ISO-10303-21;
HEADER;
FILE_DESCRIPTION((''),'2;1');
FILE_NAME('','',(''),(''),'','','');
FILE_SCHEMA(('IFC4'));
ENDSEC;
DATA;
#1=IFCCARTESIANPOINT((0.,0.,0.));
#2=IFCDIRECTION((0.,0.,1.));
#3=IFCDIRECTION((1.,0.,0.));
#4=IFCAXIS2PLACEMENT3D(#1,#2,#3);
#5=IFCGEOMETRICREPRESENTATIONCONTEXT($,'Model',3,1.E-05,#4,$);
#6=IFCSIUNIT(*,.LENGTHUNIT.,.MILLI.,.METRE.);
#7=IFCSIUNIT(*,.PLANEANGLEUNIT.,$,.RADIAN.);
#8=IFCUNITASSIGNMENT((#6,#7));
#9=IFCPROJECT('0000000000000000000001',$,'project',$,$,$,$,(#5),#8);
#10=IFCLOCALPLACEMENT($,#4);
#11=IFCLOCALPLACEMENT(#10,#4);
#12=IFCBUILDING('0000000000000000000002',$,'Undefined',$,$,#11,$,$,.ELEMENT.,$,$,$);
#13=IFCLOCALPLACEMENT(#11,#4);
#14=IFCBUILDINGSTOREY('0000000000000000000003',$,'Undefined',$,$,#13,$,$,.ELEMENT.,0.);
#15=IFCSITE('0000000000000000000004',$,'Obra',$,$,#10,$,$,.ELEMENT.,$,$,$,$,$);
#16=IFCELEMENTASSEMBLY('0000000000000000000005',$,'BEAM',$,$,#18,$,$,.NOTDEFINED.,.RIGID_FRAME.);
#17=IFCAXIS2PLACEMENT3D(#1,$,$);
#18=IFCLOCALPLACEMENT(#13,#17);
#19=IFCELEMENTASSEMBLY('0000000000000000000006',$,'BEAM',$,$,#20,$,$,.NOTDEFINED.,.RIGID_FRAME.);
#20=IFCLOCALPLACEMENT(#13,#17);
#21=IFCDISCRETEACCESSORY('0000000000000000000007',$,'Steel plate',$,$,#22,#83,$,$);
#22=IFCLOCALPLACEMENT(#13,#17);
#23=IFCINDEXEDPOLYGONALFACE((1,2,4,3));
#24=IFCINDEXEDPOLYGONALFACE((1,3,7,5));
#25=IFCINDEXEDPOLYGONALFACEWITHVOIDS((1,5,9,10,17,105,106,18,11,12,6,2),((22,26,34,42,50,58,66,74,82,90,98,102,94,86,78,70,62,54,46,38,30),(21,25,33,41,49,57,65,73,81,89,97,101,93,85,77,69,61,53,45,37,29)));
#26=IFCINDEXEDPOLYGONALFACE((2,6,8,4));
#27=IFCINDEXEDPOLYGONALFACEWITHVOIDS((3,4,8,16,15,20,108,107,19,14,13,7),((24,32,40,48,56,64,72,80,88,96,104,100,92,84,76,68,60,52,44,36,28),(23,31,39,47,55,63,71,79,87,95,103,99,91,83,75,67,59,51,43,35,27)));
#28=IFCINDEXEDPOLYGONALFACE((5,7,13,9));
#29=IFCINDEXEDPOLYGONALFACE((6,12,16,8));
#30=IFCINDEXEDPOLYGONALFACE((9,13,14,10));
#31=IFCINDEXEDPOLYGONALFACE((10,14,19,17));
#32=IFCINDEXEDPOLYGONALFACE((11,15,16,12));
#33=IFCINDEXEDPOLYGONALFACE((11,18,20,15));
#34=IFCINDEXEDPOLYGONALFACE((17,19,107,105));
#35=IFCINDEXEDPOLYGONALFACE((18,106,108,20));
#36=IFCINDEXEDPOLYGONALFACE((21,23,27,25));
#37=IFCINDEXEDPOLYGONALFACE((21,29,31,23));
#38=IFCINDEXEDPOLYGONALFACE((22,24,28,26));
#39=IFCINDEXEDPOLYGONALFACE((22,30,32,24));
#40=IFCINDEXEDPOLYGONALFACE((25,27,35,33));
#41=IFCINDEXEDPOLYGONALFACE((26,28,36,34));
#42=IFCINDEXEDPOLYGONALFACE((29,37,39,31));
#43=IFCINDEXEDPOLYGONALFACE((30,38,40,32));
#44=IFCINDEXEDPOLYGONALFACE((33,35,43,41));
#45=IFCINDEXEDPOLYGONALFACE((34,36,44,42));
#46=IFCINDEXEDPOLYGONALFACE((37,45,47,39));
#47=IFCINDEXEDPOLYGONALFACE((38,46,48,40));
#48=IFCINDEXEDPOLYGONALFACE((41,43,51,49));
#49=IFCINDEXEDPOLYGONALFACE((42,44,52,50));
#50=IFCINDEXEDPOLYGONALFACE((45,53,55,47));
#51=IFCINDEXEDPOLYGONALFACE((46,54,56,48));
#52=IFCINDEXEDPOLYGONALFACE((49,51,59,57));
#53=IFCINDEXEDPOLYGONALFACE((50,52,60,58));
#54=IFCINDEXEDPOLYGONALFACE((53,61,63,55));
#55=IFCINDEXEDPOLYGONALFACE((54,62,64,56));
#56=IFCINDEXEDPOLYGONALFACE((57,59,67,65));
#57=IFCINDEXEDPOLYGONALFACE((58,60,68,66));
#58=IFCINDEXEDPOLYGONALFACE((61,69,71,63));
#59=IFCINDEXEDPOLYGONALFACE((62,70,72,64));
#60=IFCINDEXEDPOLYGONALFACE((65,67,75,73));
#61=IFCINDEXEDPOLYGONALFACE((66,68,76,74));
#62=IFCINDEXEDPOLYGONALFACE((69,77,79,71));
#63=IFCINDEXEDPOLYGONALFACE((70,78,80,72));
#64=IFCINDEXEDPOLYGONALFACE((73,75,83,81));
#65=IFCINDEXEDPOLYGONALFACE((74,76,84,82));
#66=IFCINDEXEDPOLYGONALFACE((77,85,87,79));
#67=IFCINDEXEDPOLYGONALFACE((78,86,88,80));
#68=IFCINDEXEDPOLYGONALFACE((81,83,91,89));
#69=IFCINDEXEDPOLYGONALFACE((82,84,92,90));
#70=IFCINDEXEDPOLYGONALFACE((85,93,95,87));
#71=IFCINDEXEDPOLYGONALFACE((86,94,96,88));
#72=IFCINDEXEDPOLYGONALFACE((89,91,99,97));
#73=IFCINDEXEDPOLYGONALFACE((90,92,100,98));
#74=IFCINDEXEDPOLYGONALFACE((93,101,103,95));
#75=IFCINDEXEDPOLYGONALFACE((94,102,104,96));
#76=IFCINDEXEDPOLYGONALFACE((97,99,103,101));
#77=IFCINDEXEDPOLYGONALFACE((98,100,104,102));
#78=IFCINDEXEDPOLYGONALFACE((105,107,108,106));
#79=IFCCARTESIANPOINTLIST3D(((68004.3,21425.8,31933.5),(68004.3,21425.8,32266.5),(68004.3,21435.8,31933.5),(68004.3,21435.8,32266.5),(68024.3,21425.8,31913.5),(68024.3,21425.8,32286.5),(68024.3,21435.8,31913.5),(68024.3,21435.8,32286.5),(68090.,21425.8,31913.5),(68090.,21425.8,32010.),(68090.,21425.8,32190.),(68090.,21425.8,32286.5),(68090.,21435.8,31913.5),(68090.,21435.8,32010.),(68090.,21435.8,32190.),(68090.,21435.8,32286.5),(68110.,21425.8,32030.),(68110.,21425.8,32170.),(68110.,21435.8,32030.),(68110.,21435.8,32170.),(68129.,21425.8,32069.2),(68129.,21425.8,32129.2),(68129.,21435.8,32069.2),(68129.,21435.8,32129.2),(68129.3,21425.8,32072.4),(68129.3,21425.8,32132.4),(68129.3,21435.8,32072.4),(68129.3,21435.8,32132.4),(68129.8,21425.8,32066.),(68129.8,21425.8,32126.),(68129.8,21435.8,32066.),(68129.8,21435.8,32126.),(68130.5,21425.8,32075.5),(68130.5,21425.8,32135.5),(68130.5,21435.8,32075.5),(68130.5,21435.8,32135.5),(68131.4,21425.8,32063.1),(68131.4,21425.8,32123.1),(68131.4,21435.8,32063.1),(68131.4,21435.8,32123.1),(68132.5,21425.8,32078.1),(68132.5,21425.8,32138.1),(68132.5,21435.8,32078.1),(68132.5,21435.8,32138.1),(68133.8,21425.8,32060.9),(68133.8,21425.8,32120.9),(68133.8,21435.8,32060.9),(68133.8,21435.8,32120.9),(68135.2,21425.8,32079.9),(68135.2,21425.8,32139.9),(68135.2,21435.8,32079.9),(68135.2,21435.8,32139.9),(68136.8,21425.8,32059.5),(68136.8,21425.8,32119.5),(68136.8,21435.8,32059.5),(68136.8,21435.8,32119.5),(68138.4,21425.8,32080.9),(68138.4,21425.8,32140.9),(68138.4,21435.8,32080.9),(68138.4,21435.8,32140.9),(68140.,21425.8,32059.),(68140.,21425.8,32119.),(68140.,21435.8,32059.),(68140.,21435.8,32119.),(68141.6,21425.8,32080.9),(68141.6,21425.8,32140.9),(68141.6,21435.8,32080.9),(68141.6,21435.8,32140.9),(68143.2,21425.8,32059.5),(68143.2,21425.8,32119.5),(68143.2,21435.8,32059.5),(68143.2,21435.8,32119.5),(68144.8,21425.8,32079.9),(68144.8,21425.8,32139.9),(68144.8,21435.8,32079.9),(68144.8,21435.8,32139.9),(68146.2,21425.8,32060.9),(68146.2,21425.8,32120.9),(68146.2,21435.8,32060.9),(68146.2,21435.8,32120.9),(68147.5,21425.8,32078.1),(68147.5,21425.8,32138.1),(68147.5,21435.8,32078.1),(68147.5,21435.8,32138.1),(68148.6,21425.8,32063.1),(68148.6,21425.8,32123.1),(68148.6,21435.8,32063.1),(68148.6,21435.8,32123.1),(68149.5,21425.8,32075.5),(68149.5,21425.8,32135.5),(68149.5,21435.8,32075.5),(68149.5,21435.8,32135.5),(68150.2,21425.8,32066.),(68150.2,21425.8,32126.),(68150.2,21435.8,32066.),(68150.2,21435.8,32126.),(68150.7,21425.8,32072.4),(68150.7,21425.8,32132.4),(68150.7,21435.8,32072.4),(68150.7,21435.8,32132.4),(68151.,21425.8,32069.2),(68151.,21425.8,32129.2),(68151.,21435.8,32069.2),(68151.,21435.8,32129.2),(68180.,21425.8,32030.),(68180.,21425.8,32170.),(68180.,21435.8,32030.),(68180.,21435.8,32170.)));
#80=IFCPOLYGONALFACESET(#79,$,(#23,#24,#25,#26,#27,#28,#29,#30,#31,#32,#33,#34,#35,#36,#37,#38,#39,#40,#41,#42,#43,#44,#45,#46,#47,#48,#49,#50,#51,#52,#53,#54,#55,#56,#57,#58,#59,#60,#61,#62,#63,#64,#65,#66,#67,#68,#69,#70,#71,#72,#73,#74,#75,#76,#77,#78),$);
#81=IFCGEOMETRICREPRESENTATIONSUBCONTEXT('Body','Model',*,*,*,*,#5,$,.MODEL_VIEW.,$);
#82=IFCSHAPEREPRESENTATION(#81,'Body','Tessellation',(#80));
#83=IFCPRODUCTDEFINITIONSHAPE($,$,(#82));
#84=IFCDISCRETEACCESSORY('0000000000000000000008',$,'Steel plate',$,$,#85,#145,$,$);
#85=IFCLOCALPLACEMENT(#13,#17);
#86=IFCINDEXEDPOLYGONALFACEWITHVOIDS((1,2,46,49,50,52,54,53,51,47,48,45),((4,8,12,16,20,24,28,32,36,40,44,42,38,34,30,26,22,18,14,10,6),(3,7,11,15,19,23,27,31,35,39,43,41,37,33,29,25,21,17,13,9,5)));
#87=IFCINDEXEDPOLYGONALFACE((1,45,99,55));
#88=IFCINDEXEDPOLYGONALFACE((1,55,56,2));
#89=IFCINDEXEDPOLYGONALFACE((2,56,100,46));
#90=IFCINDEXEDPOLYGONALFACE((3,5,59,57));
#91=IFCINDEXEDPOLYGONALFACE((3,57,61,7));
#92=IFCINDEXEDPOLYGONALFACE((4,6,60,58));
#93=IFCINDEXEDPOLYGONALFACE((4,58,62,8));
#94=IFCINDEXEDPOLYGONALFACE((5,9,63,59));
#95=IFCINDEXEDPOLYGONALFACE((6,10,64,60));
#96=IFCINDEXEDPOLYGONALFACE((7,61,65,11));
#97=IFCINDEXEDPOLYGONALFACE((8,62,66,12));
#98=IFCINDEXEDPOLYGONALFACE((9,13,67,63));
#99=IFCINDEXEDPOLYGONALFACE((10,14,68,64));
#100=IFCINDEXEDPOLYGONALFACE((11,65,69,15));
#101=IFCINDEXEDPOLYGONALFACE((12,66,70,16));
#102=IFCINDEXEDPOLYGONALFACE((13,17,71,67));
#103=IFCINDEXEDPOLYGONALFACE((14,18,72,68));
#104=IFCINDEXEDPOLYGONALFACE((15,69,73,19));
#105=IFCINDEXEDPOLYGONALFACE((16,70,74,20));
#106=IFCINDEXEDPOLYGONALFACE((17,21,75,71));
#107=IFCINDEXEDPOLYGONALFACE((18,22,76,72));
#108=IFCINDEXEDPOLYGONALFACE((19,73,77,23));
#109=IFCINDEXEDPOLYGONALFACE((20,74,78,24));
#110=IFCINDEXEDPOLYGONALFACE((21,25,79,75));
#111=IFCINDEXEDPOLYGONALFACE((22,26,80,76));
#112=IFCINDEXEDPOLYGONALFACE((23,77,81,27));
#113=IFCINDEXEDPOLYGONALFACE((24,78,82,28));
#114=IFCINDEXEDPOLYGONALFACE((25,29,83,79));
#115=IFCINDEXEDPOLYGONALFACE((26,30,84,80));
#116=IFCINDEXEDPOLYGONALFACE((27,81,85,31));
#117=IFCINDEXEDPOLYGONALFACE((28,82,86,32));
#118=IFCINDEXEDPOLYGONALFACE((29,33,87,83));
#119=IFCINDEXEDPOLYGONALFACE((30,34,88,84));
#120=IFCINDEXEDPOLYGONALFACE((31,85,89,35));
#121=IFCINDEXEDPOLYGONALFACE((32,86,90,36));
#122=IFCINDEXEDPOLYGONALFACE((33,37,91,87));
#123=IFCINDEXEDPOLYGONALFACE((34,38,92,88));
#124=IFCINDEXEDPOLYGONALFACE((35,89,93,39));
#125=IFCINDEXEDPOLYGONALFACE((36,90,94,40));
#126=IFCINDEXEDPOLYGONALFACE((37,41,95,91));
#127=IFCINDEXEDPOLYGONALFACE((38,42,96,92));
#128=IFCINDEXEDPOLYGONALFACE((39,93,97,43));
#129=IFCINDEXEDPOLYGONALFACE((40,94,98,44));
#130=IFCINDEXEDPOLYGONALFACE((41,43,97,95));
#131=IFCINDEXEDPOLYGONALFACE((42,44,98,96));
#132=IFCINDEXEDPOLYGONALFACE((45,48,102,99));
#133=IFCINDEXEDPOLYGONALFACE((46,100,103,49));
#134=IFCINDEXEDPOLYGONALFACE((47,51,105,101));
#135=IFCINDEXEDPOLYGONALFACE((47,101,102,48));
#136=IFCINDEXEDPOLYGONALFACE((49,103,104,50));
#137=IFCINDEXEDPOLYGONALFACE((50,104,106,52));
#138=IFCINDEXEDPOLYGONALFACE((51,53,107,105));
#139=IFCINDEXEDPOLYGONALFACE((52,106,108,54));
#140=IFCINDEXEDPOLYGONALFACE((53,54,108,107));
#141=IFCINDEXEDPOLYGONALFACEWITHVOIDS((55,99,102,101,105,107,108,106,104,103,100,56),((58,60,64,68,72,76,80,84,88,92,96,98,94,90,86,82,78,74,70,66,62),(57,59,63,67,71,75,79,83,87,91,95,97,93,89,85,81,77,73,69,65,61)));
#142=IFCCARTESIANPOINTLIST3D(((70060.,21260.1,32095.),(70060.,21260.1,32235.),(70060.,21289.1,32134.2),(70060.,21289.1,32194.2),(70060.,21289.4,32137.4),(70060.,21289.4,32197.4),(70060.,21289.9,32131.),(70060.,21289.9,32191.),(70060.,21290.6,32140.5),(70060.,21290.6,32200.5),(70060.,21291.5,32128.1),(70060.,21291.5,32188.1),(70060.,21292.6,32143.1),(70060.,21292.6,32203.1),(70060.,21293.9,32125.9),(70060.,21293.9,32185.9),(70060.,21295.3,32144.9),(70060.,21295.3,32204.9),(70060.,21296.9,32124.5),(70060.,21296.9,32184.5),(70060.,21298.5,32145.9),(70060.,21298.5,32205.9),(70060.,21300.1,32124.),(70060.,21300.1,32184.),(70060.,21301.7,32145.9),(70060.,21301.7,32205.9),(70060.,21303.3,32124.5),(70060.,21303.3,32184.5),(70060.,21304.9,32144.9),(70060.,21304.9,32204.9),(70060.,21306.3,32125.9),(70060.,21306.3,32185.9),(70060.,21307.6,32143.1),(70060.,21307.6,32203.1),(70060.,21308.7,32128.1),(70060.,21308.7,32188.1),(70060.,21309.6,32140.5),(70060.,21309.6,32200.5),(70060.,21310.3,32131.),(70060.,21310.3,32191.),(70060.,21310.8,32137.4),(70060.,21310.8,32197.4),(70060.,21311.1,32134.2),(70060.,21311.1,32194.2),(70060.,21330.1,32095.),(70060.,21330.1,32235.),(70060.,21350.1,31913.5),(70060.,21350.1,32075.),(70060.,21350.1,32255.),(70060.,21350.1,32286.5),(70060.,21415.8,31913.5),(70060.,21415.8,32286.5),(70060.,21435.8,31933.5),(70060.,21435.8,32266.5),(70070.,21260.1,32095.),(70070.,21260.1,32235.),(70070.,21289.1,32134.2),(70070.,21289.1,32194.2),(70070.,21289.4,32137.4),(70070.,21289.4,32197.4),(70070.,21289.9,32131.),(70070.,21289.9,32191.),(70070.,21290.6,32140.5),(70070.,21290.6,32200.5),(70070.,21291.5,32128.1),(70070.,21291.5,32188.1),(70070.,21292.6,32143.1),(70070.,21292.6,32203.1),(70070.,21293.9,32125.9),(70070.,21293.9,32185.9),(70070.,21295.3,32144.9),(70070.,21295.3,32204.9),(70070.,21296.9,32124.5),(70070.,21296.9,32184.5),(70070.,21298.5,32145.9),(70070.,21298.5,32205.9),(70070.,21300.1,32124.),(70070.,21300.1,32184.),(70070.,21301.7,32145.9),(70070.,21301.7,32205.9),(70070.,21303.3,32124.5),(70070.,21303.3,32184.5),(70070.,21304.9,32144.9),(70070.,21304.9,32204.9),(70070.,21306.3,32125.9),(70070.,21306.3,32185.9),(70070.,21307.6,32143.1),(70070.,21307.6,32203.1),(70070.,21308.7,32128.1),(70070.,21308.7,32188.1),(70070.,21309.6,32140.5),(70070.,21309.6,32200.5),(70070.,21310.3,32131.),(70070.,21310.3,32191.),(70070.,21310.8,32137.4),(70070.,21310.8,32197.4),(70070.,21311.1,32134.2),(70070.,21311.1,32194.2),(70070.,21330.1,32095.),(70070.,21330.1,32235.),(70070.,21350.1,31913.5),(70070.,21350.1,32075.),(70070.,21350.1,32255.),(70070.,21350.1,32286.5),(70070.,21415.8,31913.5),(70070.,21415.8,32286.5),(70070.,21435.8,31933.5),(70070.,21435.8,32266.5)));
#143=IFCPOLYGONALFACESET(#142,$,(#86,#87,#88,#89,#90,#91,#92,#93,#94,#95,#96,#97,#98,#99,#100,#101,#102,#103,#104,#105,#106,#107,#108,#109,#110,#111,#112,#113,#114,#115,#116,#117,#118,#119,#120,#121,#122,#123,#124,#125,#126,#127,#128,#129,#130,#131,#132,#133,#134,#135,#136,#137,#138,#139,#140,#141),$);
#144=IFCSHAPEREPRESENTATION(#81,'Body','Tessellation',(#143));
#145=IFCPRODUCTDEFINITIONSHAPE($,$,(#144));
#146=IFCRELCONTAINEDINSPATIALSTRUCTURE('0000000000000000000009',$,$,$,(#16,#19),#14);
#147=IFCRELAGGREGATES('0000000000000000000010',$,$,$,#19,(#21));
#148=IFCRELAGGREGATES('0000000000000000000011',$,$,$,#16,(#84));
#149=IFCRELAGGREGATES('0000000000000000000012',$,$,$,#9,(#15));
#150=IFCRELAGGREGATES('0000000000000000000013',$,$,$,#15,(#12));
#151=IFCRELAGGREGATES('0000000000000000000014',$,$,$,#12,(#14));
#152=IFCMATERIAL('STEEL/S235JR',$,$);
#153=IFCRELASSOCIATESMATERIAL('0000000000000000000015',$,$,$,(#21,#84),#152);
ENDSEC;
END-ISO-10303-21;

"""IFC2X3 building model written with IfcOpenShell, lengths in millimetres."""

from ifc_helpers import new_model, si_unit, frame, origin_with_axes, origin_2d_with_axis, place, context, subcontext, project, spatial, polyline, circle, outline, extrude, source, transform, mapped, material, element, aggregate, save


model = new_model("IFC2X3")

# Units and contexts
model_context = context("Model", 3, precision=1e-05, world=origin_with_axes())
body_context = subcontext(model_context, "Body", "Model", "MODEL_VIEW")
ifc_project = project(units=[si_unit("LENGTHUNIT", "METRE", prefix="MILLI"), si_unit("PLANEANGLEUNIT", "RADIAN")], contexts=[model_context])

# Site, building, storey
site_placement = place(None, origin_with_axes())
site = spatial("IfcSite", under=ifc_project, at=site_placement, Name="Obra", CompositionType="ELEMENT")
building_placement = place(site_placement, origin_with_axes())
building = spatial("IfcBuilding", under=site, at=building_placement, Name="Undefined", CompositionType="ELEMENT")
storey_placement = place(building_placement, origin_with_axes())
storey = spatial("IfcBuildingStorey", under=building, at=storey_placement, Name="Undefined", CompositionType="ELEMENT", Elevation=0.0)

# Shared definitions
ifc_material_1 = material(Name="STEEL/S235JR")

# Element assembly
assembly_1_placement = place(storey_placement, origin_with_axes())
assembly_1 = element("IfcElementAssembly", 1, at=assembly_1_placement, inside=storey, Name="BEAM", AssemblyPlace="NOTDEFINED", PredefinedType="RIGID_FRAME")

# Element assembly
assembly_2_placement = place(storey_placement, origin_with_axes())
assembly_2 = element("IfcElementAssembly", 2, at=assembly_2_placement, inside=storey, Name="BEAM", AssemblyPlace="NOTDEFINED", PredefinedType="RIGID_FRAME")

# Discrete accessories, openings
discrete_accessory_1_placement = place(assembly_2_placement, frame((68004.3, 21430.8, 31933.5), z_axis=(0.0, -1.0, 0.0), x_axis=(0.707107, 0.0, -0.707107)))
discrete_accessory_1 = element("IfcDiscreteAccessory", 3, at=discrete_accessory_1_placement, material=ifc_material_1, Name="Steel plate", context=body_context, shape_type="SweptSolid", body=[
    extrude(outline(polyline([(0.0, 0.0), (28.3, 0.0), (74.7, 46.5), (6.5, 114.7), (6.5, 143.0), (56.0, 192.5), (-43.0, 291.5), (-92.5, 242.0), (-120.8, 242.0), (-189.0, 310.2), (-235.5, 263.8), (-235.5, 235.5), (0.0, 0.0)])), frame((0.0, 0.0, -5.0), z_axis=(0.0, 0.0, 1.0), x_axis=(1.0, 0.0, 0.0)), (0.0, 0.0, 1.0), 10.0),
])
shared_shape_1 = source(origin_with_axes(), body_context, "Body", "SweptSolid", [
    extrude(circle(Radius=11.0, at=origin_2d_with_axis()), frame((0.0, -14.4, 0.0), z_axis=(0.0, 1.0, 0.0), x_axis=(1.0, 0.0, 0.0)), (0.0, 0.0, 1.0), 10.2),
])
opening_1_placement = place(assembly_2_placement, frame((68100.0, 21440.1, 32170.0), z_axis=(1.0, 0.0, 0.0), x_axis=(0.0, 0.0, -1.0)))
element("IfcOpeningElement", 4, at=opening_1_placement, cuts=discrete_accessory_1, ObjectType="Opening", context=body_context, shape_type="MappedRepresentation", body=[
    mapped(shared_shape_1, transform((40.0, 0.0, 40.0))),
    mapped(shared_shape_1, transform((100.0, 0.0, 40.0))),
])
aggregate(assembly_2, [discrete_accessory_1])
discrete_accessory_2_placement = place(assembly_1_placement, frame((70065.0, 21435.8, 31933.5), z_axis=(-1.0, 0.0, 0.0), x_axis=(0.0, -0.707107, -0.707107)))
discrete_accessory_2 = element("IfcDiscreteAccessory", 5, at=discrete_accessory_2_placement, material=ifc_material_1, Name="Steel plate", context=body_context, shape_type="SweptSolid", body=[
    extrude(outline(polyline([(0.0, 0.0), (28.3, 0.0), (74.7, 46.5), (-39.5, 160.7), (-39.5, 188.9), (10.0, 238.4), (-89.0, 337.4), (-138.5, 287.9), (-166.7, 287.9), (-189.0, 310.2), (-235.5, 263.8), (-235.5, 235.5), (0.0, 0.0)])), frame((0.0, 0.0, -5.0), z_axis=(0.0, 0.0, 1.0), x_axis=(1.0, 0.0, 0.0)), (0.0, 0.0, 1.0), 10.0),
])
shared_shape_2 = source(origin_with_axes(), body_context, "Body", "SweptSolid", [
    extrude(circle(Radius=11.0, at=origin_2d_with_axis()), frame((0.0, -13.4, 0.0), z_axis=(0.0, 1.0, 0.0), x_axis=(1.0, 0.0, 0.0)), (0.0, 0.0, 1.0), 10.2),
])
opening_2_placement = place(assembly_1_placement, frame((70073.3, 21340.1, 32235.0), z_axis=(0.0, -1.0, 0.0), x_axis=(0.0, 0.0, -1.0)))
element("IfcOpeningElement", 6, at=opening_2_placement, cuts=discrete_accessory_2, ObjectType="Opening", context=body_context, shape_type="MappedRepresentation", body=[
    mapped(shared_shape_2, transform((40.0, 0.0, 40.0))),
    mapped(shared_shape_2, transform((100.0, 0.0, 40.0))),
])
aggregate(assembly_1, [discrete_accessory_2])

save(model, "model.ifc")
